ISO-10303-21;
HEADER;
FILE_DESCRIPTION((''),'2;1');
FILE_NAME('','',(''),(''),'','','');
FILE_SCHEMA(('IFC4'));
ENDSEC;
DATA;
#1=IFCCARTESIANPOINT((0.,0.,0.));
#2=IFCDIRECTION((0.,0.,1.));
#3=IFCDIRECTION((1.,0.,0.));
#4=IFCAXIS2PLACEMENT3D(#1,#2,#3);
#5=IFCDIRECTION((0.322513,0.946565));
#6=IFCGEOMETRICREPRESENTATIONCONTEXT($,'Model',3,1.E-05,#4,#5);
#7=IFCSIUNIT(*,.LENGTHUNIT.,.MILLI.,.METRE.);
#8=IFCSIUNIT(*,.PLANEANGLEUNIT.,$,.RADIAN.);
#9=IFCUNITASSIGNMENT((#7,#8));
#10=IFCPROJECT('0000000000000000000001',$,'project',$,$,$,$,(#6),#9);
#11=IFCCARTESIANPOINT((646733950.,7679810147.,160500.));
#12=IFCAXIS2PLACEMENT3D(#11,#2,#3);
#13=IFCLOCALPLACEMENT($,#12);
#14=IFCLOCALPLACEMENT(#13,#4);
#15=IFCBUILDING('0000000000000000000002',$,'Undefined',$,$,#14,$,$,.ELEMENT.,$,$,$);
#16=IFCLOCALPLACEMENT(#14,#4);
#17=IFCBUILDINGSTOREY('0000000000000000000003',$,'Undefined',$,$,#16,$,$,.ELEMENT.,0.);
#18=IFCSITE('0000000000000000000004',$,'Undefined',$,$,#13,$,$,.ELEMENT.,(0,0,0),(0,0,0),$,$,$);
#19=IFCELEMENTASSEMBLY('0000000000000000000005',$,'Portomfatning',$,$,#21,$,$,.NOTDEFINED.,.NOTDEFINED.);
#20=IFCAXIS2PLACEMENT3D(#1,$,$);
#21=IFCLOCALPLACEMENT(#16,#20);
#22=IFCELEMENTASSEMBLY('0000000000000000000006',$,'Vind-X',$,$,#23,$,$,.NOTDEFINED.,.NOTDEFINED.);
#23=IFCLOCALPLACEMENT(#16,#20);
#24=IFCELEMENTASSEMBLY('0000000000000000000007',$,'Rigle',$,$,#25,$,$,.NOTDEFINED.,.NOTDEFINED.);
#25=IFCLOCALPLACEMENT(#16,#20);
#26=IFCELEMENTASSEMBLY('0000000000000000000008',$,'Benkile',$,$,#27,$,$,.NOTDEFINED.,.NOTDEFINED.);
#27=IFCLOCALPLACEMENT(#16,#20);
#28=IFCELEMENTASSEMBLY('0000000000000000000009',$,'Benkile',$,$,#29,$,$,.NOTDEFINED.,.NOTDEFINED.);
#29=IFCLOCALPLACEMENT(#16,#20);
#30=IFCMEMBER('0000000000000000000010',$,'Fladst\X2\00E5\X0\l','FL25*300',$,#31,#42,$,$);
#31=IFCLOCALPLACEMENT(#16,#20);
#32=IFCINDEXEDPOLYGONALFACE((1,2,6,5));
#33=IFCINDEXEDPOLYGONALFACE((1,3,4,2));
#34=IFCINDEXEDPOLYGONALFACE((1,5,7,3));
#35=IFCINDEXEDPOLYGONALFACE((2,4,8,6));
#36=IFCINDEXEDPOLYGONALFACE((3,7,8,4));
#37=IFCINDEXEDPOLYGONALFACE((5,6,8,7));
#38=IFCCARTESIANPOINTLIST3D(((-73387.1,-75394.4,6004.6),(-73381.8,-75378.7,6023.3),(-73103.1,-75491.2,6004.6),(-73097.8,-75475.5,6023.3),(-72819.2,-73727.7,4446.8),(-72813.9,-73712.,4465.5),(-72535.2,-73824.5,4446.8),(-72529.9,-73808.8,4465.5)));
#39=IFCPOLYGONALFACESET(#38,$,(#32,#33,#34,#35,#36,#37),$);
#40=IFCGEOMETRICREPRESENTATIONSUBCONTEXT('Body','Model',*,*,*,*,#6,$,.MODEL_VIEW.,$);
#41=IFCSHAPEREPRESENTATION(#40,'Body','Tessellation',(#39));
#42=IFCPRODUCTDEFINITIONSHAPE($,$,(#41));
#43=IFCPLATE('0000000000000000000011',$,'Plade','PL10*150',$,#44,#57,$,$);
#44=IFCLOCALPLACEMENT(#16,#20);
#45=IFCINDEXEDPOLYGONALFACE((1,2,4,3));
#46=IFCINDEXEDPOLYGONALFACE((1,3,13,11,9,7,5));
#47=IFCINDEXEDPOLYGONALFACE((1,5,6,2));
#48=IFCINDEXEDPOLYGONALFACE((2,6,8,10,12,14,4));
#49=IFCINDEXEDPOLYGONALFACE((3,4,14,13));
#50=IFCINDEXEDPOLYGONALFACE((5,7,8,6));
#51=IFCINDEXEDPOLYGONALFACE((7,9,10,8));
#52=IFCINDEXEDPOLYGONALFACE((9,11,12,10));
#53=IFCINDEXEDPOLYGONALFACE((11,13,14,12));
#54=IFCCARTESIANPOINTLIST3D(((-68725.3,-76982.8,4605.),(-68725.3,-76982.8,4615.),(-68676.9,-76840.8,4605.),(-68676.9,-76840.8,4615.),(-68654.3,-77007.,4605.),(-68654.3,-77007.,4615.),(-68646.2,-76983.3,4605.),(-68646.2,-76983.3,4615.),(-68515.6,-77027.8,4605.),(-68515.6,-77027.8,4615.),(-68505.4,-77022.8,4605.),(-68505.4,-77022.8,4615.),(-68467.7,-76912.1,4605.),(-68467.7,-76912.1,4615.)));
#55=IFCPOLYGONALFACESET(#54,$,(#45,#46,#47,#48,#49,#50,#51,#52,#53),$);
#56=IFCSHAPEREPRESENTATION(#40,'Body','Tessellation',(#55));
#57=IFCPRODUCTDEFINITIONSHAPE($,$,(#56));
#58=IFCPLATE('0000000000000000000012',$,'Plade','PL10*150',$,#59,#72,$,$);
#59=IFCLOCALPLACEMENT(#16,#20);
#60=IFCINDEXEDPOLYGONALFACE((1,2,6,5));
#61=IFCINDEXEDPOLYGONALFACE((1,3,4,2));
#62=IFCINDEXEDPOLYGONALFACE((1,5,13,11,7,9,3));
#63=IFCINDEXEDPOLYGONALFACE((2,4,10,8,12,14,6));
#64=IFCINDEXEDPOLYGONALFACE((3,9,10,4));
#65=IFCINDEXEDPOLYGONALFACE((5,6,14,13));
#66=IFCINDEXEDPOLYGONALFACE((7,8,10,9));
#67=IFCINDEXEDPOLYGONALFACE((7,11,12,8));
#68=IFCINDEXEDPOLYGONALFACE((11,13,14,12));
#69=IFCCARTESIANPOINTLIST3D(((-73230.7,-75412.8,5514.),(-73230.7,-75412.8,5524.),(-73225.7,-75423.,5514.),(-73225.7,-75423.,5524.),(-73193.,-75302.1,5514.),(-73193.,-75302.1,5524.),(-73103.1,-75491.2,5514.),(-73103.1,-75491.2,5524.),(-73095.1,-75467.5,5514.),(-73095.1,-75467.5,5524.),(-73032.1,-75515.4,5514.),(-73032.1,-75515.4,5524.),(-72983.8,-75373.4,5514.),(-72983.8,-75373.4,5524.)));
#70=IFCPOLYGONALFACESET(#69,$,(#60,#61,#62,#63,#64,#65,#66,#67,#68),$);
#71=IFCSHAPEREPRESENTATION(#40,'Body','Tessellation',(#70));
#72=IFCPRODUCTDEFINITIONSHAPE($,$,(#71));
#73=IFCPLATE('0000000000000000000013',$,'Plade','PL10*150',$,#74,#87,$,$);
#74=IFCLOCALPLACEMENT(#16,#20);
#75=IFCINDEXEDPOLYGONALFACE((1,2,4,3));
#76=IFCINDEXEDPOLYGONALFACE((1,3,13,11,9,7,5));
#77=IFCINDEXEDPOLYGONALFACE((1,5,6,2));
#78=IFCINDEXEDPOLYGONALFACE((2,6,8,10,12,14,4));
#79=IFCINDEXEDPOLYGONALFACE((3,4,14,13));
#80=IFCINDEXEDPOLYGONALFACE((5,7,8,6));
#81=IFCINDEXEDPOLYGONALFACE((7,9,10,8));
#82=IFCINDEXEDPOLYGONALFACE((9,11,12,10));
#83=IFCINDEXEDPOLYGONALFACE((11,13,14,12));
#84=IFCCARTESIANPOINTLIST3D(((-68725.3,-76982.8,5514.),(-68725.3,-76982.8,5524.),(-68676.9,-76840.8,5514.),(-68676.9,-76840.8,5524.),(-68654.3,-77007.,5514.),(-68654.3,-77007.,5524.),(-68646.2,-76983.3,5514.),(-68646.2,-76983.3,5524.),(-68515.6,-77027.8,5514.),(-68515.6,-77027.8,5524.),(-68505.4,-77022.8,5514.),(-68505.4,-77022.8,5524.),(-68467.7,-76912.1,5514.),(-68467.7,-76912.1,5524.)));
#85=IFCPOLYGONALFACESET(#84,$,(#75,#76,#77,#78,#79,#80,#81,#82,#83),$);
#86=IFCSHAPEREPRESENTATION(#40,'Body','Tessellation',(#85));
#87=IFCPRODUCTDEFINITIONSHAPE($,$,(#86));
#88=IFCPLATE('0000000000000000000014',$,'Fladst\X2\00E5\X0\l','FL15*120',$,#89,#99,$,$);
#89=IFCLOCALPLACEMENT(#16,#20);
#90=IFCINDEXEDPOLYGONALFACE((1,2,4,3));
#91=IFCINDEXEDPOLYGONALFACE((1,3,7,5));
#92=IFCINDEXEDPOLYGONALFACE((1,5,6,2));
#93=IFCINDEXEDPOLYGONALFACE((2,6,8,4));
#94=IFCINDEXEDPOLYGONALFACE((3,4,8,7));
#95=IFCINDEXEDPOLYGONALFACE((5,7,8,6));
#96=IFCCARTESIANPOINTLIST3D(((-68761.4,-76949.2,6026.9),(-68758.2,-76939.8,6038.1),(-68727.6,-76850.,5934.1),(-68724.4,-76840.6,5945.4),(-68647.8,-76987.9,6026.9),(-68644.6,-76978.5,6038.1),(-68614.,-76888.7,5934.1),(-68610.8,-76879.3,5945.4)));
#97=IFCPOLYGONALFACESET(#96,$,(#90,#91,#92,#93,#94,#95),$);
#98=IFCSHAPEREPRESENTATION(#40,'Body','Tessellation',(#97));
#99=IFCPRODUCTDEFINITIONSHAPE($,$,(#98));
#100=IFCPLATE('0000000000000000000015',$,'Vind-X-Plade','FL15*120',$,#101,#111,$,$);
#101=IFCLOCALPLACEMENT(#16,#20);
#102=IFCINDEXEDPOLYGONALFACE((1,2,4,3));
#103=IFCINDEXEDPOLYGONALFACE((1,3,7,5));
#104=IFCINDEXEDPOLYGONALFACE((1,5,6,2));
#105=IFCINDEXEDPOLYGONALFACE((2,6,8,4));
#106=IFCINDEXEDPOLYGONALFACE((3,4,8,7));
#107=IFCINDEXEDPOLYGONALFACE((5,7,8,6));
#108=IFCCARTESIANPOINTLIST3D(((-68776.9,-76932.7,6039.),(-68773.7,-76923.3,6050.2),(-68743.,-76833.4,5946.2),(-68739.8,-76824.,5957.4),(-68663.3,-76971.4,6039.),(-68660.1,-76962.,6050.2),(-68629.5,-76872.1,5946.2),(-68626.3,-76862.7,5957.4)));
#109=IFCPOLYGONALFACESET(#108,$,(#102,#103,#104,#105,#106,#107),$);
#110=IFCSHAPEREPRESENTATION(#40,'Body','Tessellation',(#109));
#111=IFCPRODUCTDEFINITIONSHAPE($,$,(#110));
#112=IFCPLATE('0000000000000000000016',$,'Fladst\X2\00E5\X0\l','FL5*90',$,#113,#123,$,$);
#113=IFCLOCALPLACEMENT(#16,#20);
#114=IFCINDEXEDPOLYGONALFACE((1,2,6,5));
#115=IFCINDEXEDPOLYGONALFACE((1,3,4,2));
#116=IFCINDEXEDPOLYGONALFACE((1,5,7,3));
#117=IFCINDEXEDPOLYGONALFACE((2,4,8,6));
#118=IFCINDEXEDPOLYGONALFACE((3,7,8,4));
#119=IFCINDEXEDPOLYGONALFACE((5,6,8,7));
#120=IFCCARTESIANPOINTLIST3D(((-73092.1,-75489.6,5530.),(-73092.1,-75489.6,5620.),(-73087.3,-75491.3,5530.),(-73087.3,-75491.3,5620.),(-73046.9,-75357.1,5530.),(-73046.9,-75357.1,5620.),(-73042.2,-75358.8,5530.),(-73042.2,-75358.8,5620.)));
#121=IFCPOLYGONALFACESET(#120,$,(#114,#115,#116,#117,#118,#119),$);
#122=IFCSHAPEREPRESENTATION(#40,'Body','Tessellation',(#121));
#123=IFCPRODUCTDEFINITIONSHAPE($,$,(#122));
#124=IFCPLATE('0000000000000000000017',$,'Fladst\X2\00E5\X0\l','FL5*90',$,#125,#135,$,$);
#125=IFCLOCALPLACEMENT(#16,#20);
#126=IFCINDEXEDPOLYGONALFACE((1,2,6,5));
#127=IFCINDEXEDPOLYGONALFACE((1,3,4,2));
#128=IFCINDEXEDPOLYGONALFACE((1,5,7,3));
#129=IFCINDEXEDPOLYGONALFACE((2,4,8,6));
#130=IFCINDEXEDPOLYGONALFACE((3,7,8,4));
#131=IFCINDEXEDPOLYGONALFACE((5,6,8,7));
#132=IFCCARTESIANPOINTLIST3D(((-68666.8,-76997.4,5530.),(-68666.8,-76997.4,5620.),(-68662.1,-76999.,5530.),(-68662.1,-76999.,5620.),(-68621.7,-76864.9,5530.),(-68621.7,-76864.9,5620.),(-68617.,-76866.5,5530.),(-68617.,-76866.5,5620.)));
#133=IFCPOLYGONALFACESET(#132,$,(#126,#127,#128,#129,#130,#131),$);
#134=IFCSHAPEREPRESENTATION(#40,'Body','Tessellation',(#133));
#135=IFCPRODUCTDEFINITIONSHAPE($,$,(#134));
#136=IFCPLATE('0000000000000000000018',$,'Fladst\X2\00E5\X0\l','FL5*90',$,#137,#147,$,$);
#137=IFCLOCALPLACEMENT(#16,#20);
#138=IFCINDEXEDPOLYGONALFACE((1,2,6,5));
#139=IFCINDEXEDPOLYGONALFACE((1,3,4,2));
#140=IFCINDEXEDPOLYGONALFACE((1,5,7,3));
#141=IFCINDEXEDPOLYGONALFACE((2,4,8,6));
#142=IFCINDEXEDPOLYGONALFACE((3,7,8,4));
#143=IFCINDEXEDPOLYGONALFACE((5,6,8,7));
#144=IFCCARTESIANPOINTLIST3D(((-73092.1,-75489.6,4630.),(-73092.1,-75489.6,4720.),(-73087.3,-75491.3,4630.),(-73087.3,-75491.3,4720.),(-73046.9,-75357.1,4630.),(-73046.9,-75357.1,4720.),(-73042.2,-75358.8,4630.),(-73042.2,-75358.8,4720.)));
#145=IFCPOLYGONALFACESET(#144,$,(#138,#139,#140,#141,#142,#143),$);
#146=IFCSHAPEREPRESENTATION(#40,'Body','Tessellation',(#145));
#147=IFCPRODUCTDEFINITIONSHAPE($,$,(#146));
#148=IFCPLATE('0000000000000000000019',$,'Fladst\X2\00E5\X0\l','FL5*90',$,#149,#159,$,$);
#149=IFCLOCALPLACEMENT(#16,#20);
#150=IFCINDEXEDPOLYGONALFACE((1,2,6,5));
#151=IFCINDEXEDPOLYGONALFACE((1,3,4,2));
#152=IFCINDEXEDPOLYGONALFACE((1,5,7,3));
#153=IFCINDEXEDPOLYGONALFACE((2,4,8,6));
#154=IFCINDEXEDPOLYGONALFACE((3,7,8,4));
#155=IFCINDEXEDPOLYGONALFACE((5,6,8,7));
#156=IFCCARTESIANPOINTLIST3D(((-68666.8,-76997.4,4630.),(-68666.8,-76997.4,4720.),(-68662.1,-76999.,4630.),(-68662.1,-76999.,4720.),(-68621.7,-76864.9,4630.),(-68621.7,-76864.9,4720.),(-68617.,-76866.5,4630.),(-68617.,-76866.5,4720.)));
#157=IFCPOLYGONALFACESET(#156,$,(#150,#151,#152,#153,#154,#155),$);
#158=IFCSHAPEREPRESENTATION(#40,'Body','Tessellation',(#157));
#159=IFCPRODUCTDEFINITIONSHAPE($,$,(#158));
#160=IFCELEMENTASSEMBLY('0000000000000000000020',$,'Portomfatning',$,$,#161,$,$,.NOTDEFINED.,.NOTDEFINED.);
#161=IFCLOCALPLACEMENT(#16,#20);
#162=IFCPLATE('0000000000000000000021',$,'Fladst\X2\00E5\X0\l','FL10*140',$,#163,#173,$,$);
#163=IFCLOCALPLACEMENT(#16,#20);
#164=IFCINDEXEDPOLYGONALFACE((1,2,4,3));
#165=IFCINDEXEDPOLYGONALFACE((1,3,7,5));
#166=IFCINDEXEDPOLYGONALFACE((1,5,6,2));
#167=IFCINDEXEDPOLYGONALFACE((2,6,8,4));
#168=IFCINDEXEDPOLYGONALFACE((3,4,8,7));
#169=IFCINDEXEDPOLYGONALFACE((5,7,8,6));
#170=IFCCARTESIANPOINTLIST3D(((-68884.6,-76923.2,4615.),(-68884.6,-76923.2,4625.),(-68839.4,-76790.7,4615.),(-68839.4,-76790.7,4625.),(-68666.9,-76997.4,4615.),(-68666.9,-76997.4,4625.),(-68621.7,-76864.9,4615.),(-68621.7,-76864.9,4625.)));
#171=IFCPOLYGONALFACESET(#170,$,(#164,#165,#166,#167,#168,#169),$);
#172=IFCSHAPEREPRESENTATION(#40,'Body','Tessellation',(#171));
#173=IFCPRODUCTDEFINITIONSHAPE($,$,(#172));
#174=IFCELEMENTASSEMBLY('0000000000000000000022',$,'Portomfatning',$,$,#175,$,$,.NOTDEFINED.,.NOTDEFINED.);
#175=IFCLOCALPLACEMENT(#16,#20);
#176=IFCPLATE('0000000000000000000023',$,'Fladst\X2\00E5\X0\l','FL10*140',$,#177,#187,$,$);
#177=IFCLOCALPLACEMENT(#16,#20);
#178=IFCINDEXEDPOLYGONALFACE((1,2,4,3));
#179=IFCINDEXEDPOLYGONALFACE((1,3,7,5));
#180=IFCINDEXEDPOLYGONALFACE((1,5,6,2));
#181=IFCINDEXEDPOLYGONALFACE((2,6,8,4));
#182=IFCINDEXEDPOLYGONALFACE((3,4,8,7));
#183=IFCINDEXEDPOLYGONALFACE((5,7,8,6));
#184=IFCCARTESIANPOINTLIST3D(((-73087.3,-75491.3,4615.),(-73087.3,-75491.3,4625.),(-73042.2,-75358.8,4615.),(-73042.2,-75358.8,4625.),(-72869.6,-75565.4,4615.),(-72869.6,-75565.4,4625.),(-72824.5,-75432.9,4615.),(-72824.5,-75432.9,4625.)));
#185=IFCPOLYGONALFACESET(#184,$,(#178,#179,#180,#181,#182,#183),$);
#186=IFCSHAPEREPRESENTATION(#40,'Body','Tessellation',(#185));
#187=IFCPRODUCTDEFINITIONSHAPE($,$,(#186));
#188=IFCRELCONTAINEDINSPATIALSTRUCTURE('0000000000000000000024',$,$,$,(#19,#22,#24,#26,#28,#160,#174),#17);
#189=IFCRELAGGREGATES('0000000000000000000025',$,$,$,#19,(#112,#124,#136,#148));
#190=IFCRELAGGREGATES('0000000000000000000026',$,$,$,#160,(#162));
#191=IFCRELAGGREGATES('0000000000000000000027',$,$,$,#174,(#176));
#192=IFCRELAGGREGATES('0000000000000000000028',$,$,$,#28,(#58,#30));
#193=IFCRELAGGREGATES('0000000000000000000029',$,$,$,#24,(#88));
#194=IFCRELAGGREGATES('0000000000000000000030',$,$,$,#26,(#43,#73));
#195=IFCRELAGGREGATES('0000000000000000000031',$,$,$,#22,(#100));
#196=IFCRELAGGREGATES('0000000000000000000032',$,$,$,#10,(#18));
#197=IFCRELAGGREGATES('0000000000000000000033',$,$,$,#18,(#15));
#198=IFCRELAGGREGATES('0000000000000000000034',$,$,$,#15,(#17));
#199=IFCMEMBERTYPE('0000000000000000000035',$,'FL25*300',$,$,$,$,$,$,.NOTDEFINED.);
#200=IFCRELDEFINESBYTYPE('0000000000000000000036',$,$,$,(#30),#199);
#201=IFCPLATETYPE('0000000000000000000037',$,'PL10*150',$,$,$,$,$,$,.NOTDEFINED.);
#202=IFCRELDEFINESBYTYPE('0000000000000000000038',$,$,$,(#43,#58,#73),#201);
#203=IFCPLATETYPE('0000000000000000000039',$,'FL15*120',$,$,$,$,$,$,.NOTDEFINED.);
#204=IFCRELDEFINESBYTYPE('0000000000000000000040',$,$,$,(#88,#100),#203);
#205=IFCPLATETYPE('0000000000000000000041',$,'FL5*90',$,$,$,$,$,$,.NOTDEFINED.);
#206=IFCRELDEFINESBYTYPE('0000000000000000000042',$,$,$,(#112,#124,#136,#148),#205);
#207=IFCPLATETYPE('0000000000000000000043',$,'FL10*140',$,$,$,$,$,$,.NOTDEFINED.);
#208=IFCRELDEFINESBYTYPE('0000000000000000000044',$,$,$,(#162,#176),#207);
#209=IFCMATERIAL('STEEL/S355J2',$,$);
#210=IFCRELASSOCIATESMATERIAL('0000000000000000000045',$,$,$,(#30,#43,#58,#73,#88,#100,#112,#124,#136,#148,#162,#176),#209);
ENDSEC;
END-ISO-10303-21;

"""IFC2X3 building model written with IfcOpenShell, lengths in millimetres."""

from ifc_helpers import new_model, si_unit, direction, frame, origin_with_axes, origin_2d_with_axis, place, context, subcontext, project, spatial, polyline, rectangle, outline, extrude, boolean, material, type_object, element, aggregate, save


model = new_model("IFC2X3")

# Units and contexts
model_context = context("Model", 3, precision=1e-05, world=origin_with_axes(), true_north=direction((0.322513, 0.946565)))
body_context = subcontext(model_context, "Body", "Model", "MODEL_VIEW")
ifc_project = project(units=[si_unit("LENGTHUNIT", "METRE", prefix="MILLI"), si_unit("PLANEANGLEUNIT", "RADIAN")], contexts=[model_context])

# Site, building, storey
site_placement = place(None, frame((646733950.0, 7679810147.0, 160500.0), z_axis=(0.0, 0.0, 1.0), x_axis=(1.0, 0.0, 0.0)))
site = spatial("IfcSite", under=ifc_project, at=site_placement, Name="Undefined", CompositionType="ELEMENT", RefLatitude=(0, 0, 0), RefLongitude=(0, 0, 0))
building_placement = place(site_placement, origin_with_axes())
building = spatial("IfcBuilding", under=site, at=building_placement, Name="Undefined", CompositionType="ELEMENT")
storey_placement = place(building_placement, origin_with_axes())
storey = spatial("IfcBuildingStorey", under=building, at=storey_placement, Name="Undefined", CompositionType="ELEMENT", Elevation=0.0)

# Element assembly
assembly_1_placement = place(storey_placement, origin_with_axes())
assembly_1 = element("IfcElementAssembly", 1, at=assembly_1_placement, inside=storey, Name="Portomfatning", AssemblyPlace="NOTDEFINED", PredefinedType="NOTDEFINED")

# Element assembly
assembly_2_placement = place(storey_placement, origin_with_axes())
assembly_2 = element("IfcElementAssembly", 2, at=assembly_2_placement, inside=storey, Name="Vind-X", AssemblyPlace="NOTDEFINED", PredefinedType="NOTDEFINED")

# Element assemblies, member
assembly_3_placement = place(storey_placement, origin_with_axes())
assembly_3 = element("IfcElementAssembly", 3, at=assembly_3_placement, inside=storey, Name="Rigle", AssemblyPlace="NOTDEFINED", PredefinedType="NOTDEFINED")
ifc_material_1 = material(Name="STEEL/S355J2")
member_type = type_object("IfcMemberType", Name="FL25*300", PredefinedType="NOTDEFINED")
assembly_4_placement = place(storey_placement, origin_with_axes())
assembly_4 = element("IfcElementAssembly", 4, at=assembly_4_placement, inside=storey, Name="Benkile", AssemblyPlace="NOTDEFINED", PredefinedType="NOTDEFINED")
assembly_5_placement = place(storey_placement, origin_with_axes())
assembly_5 = element("IfcElementAssembly", 5, at=assembly_5_placement, inside=storey, Name="Benkile", AssemblyPlace="NOTDEFINED", PredefinedType="NOTDEFINED")
member_1_placement = place(assembly_5_placement, frame((-73242.4, -75434.9, 6014.0), z_axis=(0.946565, -0.322513, 0.0), x_axis=(0.241548, 0.708935, -0.66262)))
member_1 = element("IfcMember", 6, at=member_1_placement, type_object=member_type, material=ifc_material_1, Name="Fladstål", Description="FL25*300", context=body_context, shape_type="SweptSolid", body=[
    extrude(rectangle(XDim=25.0, YDim=300.0, at=origin_2d_with_axis()), frame((2351.0, 0.0, 0.0), z_axis=(-1.0, 0.0, 0.0), x_axis=(0.0, -1.0, 0.0)), (0.0, 0.0, 1.0), 2351.0),
])

# Plates
plate_type_1 = type_object("IfcPlateType", Name="PL10*150", PredefinedType="NOTDEFINED")
plate_1_placement = place(assembly_4_placement, frame((-68516.1, -77054.1, 4610.0), z_axis=(0.0, 0.0, -1.0), x_axis=(-0.946565, 0.322513, 0.0)))
plate_1 = element("IfcPlate", 7, at=plate_1_placement, type_object=plate_type_1, material=ifc_material_1, Name="Plade", Description="PL10*150", context=body_context, shape_type="CSG", body=[
    boolean("DIFFERENCE", extrude(outline(polyline([(0.0, 25.0), (146.0, 25.0), (146.0, 0.0), (221.0, 0.0), (221.0, 150.0), (0.0, 150.0), (0.0, 25.0)])), frame((0.0, 0.0, -5.0), z_axis=(0.0, 0.0, 1.0), x_axis=(1.0, 0.0, 0.0)), (0.0, 0.0, 1.0), 10.0), extrude(outline(polyline([(0.0, 0.0), (8.0, 0.0), (0.0, 8.0), (0.0, 0.0)])), frame((0.0, 25.0, -7.5), z_axis=(0.0, 0.0, 1.0), x_axis=(1.0, 0.0, 0.0)), (0.0, 0.0, 1.0), 15.0)),
])
plate_2_placement = place(assembly_5_placement, frame((-73241.3, -75444.1, 5519.0), z_axis=(0.0, 0.0, 1.0), x_axis=(0.946565, -0.322513, 0.0)))
plate_2 = element("IfcPlate", 8, at=plate_2_placement, type_object=plate_type_1, material=ifc_material_1, Name="Plade", Description="PL10*150", context=body_context, shape_type="CSG", body=[
    boolean("DIFFERENCE", extrude(outline(polyline([(0.0, 25.0), (146.0, 25.0), (146.0, 0.0), (221.0, 0.0), (221.0, 150.0), (0.0, 150.0), (0.0, 25.0)])), frame((0.0, 0.0, -5.0), z_axis=(0.0, 0.0, 1.0), x_axis=(1.0, 0.0, 0.0)), (0.0, 0.0, 1.0), 10.0), extrude(outline(polyline([(0.0, 0.0), (8.0, 0.0), (0.0, 8.0), (0.0, 0.0)])), frame((0.0, 25.0, -7.5), z_axis=(0.0, 0.0, 1.0), x_axis=(1.0, 0.0, 0.0)), (0.0, 0.0, 1.0), 15.0)),
])
plate_3_placement = place(assembly_4_placement, frame((-68467.7, -76912.1, 5519.0), z_axis=(0.0, 0.0, 1.0), x_axis=(-0.946565, 0.322513, 0.0)))
plate_3 = element("IfcPlate", 9, at=plate_3_placement, type_object=plate_type_1, material=ifc_material_1, Name="Plade", Description="PL10*150", context=body_context, shape_type="CSG", body=[
    boolean("DIFFERENCE", extrude(outline(polyline([(0.0, 0.0), (221.0, 0.0), (221.0, 150.0), (146.0, 150.0), (146.0, 125.0), (0.0, 125.0), (0.0, 0.0)])), frame((0.0, 0.0, -5.0), z_axis=(0.0, 0.0, 1.0), x_axis=(1.0, 0.0, 0.0)), (0.0, 0.0, 1.0), 10.0), extrude(outline(polyline([(0.0, 0.0), (8.0, 0.0), (0.0, 8.0), (0.0, 0.0)])), frame((0.0, 125.0, 7.5), z_axis=(0.0, 0.0, -1.0), x_axis=(1.0, 0.0, 0.0)), (0.0, 0.0, 1.0), 15.0)),
])
plate_type_2 = type_object("IfcPlateType", Name="FL15*120", PredefinedType="NOTDEFINED")
plate_4_placement = place(assembly_3_placement, frame((-68612.4, -76884.0, 5939.7), z_axis=(-0.213703, -0.627213, -0.748956), x_axis=(-0.241548, -0.708935, 0.66262)))
plate_4 = element("IfcPlate", 10, at=plate_4_placement, type_object=plate_type_2, material=ifc_material_1, Name="Fladstål", Description="FL15*120", context=body_context, shape_type="SweptSolid", body=[
    extrude(outline(polyline([(0.0, 0.0), (140.0, 0.0), (140.0, 120.0), (0.0, 120.0), (0.0, 0.0)])), frame((0.0, 0.0, -7.5), z_axis=(0.0, 0.0, 1.0), x_axis=(1.0, 0.0, 0.0)), (0.0, 0.0, 1.0), 15.0),
])
plate_5_placement = place(assembly_2_placement, frame((-68644.8, -76917.1, 5998.2), z_axis=(0.213703, 0.627213, 0.748956), x_axis=(-0.946565, 0.322513, 0.0)))
plate_5 = element("IfcPlate", 11, at=plate_5_placement, type_object=plate_type_2, material=ifc_material_1, Name="Vind-X-Plade", Description="FL15*120", context=body_context, shape_type="SweptSolid", body=[
    extrude(outline(polyline([(0.0, -70.0), (0.0, 70.0), (120.0, 70.0), (120.0, -70.0), (0.0, -70.0)])), frame((0.0, 0.0, -7.5), z_axis=(0.0, 0.0, 1.0), x_axis=(1.0, 0.0, 0.0)), (0.0, 0.0, 1.0), 15.0),
])
plate_type_3 = type_object("IfcPlateType", Name="FL5*90", PredefinedType="NOTDEFINED")
plate_6_placement = place(assembly_1_placement, frame((-73089.7, -75490.5, 5530.0), z_axis=(-0.946492, 0.322727, 0.0), x_axis=(0.0, 0.0, 1.0)))
plate_6 = element("IfcPlate", 12, at=plate_6_placement, type_object=plate_type_3, material=ifc_material_1, Name="Fladstål", Description="FL5*90", context=body_context, shape_type="SweptSolid", body=[
    extrude(outline(polyline([(0.0, 0.0), (90.0, 0.0), (90.0, 140.0), (0.0, 140.0), (0.0, 0.0)])), frame((0.0, 0.0, -2.5), z_axis=(0.0, 0.0, 1.0), x_axis=(1.0, 0.0, 0.0)), (0.0, 0.0, 1.0), 5.0),
])
plate_7_placement = place(assembly_1_placement, frame((-68664.5, -76998.2, 5620.0), z_axis=(0.946638, -0.322299, 0.0), x_axis=(0.0, 0.0, -1.0)))
plate_7 = element("IfcPlate", 13, at=plate_7_placement, type_object=plate_type_3, material=ifc_material_1, Name="Fladstål", Description="FL5*90", context=body_context, shape_type="SweptSolid", body=[
    extrude(outline(polyline([(0.0, 0.0), (90.0, 0.0), (90.0, 140.0), (0.0, 140.0), (0.0, 0.0)])), frame((0.0, 0.0, -2.5), z_axis=(0.0, 0.0, 1.0), x_axis=(1.0, 0.0, 0.0)), (0.0, 0.0, 1.0), 5.0),
])
plate_8_placement = place(assembly_1_placement, frame((-73089.7, -75490.5, 4630.0), z_axis=(-0.946492, 0.322727, 0.0), x_axis=(0.0, 0.0, 1.0)))
plate_8 = element("IfcPlate", 14, at=plate_8_placement, type_object=plate_type_3, material=ifc_material_1, Name="Fladstål", Description="FL5*90", context=body_context, shape_type="SweptSolid", body=[
    extrude(outline(polyline([(0.0, 0.0), (90.0, 0.0), (90.0, 140.0), (0.0, 140.0), (0.0, 0.0)])), frame((0.0, 0.0, -2.5), z_axis=(0.0, 0.0, 1.0), x_axis=(1.0, 0.0, 0.0)), (0.0, 0.0, 1.0), 5.0),
])
plate_9_placement = place(assembly_1_placement, frame((-68664.5, -76998.2, 4720.0), z_axis=(0.946638, -0.322299, 0.0), x_axis=(0.0, 0.0, -1.0)))
plate_9 = element("IfcPlate", 15, at=plate_9_placement, type_object=plate_type_3, material=ifc_material_1, Name="Fladstål", Description="FL5*90", context=body_context, shape_type="SweptSolid", body=[
    extrude(outline(polyline([(0.0, 0.0), (90.0, 0.0), (90.0, 140.0), (0.0, 140.0), (0.0, 0.0)])), frame((0.0, 0.0, -2.5), z_axis=(0.0, 0.0, 1.0), x_axis=(1.0, 0.0, 0.0)), (0.0, 0.0, 1.0), 5.0),
])
aggregate(assembly_1, [plate_6, plate_7, plate_8, plate_9])

# Element assemblies, plates
assembly_6_placement = place(storey_placement, origin_with_axes())
assembly_6 = element("IfcElementAssembly", 16, at=assembly_6_placement, inside=storey, Name="Portomfatning", AssemblyPlace="NOTDEFINED", PredefinedType="NOTDEFINED")
plate_type_4 = type_object("IfcPlateType", Name="FL10*140", PredefinedType="NOTDEFINED")
plate_10_placement = place(assembly_6_placement, frame((-68862.0, -76857.0, 4620.0), z_axis=(0.0, 0.0, 1.0), x_axis=(0.946565, -0.322513, 0.0)))
plate_10 = element("IfcPlate", 17, at=plate_10_placement, type_object=plate_type_4, material=ifc_material_1, Name="Fladstål", Description="FL10*140", context=body_context, shape_type="SweptSolid", body=[
    extrude(outline(polyline([(0.0, -70.0), (0.0, 70.0), (230.0, 70.0), (230.0, -70.0), (0.0, -70.0)])), frame((0.0, 0.0, -5.0), z_axis=(0.0, 0.0, 1.0), x_axis=(1.0, 0.0, 0.0)), (0.0, 0.0, 1.0), 10.0),
])
aggregate(assembly_6, [plate_10])
assembly_7_placement = place(storey_placement, origin_with_axes())
assembly_7 = element("IfcElementAssembly", 18, at=assembly_7_placement, inside=storey, Name="Portomfatning", AssemblyPlace="NOTDEFINED", PredefinedType="NOTDEFINED")
plate_11_placement = place(assembly_7_placement, frame((-72847.0, -75499.2, 4620.0), z_axis=(0.0, 0.0, -1.0), x_axis=(-0.946565, 0.322513, 0.0)))
plate_11 = element("IfcPlate", 19, at=plate_11_placement, type_object=plate_type_4, material=ifc_material_1, Name="Fladstål", Description="FL10*140", context=body_context, shape_type="SweptSolid", body=[
    extrude(outline(polyline([(0.0, -70.0), (0.0, 70.0), (230.0, 70.0), (230.0, -70.0), (0.0, -70.0)])), frame((0.0, 0.0, -5.0), z_axis=(0.0, 0.0, 1.0), x_axis=(1.0, 0.0, 0.0)), (0.0, 0.0, 1.0), 10.0),
])
aggregate(assembly_7, [plate_11])

aggregate(assembly_5, [plate_2, member_1])
aggregate(assembly_3, [plate_4])

aggregate(assembly_4, [plate_1, plate_3])
aggregate(assembly_2, [plate_5])

save(model, "model.ifc")
